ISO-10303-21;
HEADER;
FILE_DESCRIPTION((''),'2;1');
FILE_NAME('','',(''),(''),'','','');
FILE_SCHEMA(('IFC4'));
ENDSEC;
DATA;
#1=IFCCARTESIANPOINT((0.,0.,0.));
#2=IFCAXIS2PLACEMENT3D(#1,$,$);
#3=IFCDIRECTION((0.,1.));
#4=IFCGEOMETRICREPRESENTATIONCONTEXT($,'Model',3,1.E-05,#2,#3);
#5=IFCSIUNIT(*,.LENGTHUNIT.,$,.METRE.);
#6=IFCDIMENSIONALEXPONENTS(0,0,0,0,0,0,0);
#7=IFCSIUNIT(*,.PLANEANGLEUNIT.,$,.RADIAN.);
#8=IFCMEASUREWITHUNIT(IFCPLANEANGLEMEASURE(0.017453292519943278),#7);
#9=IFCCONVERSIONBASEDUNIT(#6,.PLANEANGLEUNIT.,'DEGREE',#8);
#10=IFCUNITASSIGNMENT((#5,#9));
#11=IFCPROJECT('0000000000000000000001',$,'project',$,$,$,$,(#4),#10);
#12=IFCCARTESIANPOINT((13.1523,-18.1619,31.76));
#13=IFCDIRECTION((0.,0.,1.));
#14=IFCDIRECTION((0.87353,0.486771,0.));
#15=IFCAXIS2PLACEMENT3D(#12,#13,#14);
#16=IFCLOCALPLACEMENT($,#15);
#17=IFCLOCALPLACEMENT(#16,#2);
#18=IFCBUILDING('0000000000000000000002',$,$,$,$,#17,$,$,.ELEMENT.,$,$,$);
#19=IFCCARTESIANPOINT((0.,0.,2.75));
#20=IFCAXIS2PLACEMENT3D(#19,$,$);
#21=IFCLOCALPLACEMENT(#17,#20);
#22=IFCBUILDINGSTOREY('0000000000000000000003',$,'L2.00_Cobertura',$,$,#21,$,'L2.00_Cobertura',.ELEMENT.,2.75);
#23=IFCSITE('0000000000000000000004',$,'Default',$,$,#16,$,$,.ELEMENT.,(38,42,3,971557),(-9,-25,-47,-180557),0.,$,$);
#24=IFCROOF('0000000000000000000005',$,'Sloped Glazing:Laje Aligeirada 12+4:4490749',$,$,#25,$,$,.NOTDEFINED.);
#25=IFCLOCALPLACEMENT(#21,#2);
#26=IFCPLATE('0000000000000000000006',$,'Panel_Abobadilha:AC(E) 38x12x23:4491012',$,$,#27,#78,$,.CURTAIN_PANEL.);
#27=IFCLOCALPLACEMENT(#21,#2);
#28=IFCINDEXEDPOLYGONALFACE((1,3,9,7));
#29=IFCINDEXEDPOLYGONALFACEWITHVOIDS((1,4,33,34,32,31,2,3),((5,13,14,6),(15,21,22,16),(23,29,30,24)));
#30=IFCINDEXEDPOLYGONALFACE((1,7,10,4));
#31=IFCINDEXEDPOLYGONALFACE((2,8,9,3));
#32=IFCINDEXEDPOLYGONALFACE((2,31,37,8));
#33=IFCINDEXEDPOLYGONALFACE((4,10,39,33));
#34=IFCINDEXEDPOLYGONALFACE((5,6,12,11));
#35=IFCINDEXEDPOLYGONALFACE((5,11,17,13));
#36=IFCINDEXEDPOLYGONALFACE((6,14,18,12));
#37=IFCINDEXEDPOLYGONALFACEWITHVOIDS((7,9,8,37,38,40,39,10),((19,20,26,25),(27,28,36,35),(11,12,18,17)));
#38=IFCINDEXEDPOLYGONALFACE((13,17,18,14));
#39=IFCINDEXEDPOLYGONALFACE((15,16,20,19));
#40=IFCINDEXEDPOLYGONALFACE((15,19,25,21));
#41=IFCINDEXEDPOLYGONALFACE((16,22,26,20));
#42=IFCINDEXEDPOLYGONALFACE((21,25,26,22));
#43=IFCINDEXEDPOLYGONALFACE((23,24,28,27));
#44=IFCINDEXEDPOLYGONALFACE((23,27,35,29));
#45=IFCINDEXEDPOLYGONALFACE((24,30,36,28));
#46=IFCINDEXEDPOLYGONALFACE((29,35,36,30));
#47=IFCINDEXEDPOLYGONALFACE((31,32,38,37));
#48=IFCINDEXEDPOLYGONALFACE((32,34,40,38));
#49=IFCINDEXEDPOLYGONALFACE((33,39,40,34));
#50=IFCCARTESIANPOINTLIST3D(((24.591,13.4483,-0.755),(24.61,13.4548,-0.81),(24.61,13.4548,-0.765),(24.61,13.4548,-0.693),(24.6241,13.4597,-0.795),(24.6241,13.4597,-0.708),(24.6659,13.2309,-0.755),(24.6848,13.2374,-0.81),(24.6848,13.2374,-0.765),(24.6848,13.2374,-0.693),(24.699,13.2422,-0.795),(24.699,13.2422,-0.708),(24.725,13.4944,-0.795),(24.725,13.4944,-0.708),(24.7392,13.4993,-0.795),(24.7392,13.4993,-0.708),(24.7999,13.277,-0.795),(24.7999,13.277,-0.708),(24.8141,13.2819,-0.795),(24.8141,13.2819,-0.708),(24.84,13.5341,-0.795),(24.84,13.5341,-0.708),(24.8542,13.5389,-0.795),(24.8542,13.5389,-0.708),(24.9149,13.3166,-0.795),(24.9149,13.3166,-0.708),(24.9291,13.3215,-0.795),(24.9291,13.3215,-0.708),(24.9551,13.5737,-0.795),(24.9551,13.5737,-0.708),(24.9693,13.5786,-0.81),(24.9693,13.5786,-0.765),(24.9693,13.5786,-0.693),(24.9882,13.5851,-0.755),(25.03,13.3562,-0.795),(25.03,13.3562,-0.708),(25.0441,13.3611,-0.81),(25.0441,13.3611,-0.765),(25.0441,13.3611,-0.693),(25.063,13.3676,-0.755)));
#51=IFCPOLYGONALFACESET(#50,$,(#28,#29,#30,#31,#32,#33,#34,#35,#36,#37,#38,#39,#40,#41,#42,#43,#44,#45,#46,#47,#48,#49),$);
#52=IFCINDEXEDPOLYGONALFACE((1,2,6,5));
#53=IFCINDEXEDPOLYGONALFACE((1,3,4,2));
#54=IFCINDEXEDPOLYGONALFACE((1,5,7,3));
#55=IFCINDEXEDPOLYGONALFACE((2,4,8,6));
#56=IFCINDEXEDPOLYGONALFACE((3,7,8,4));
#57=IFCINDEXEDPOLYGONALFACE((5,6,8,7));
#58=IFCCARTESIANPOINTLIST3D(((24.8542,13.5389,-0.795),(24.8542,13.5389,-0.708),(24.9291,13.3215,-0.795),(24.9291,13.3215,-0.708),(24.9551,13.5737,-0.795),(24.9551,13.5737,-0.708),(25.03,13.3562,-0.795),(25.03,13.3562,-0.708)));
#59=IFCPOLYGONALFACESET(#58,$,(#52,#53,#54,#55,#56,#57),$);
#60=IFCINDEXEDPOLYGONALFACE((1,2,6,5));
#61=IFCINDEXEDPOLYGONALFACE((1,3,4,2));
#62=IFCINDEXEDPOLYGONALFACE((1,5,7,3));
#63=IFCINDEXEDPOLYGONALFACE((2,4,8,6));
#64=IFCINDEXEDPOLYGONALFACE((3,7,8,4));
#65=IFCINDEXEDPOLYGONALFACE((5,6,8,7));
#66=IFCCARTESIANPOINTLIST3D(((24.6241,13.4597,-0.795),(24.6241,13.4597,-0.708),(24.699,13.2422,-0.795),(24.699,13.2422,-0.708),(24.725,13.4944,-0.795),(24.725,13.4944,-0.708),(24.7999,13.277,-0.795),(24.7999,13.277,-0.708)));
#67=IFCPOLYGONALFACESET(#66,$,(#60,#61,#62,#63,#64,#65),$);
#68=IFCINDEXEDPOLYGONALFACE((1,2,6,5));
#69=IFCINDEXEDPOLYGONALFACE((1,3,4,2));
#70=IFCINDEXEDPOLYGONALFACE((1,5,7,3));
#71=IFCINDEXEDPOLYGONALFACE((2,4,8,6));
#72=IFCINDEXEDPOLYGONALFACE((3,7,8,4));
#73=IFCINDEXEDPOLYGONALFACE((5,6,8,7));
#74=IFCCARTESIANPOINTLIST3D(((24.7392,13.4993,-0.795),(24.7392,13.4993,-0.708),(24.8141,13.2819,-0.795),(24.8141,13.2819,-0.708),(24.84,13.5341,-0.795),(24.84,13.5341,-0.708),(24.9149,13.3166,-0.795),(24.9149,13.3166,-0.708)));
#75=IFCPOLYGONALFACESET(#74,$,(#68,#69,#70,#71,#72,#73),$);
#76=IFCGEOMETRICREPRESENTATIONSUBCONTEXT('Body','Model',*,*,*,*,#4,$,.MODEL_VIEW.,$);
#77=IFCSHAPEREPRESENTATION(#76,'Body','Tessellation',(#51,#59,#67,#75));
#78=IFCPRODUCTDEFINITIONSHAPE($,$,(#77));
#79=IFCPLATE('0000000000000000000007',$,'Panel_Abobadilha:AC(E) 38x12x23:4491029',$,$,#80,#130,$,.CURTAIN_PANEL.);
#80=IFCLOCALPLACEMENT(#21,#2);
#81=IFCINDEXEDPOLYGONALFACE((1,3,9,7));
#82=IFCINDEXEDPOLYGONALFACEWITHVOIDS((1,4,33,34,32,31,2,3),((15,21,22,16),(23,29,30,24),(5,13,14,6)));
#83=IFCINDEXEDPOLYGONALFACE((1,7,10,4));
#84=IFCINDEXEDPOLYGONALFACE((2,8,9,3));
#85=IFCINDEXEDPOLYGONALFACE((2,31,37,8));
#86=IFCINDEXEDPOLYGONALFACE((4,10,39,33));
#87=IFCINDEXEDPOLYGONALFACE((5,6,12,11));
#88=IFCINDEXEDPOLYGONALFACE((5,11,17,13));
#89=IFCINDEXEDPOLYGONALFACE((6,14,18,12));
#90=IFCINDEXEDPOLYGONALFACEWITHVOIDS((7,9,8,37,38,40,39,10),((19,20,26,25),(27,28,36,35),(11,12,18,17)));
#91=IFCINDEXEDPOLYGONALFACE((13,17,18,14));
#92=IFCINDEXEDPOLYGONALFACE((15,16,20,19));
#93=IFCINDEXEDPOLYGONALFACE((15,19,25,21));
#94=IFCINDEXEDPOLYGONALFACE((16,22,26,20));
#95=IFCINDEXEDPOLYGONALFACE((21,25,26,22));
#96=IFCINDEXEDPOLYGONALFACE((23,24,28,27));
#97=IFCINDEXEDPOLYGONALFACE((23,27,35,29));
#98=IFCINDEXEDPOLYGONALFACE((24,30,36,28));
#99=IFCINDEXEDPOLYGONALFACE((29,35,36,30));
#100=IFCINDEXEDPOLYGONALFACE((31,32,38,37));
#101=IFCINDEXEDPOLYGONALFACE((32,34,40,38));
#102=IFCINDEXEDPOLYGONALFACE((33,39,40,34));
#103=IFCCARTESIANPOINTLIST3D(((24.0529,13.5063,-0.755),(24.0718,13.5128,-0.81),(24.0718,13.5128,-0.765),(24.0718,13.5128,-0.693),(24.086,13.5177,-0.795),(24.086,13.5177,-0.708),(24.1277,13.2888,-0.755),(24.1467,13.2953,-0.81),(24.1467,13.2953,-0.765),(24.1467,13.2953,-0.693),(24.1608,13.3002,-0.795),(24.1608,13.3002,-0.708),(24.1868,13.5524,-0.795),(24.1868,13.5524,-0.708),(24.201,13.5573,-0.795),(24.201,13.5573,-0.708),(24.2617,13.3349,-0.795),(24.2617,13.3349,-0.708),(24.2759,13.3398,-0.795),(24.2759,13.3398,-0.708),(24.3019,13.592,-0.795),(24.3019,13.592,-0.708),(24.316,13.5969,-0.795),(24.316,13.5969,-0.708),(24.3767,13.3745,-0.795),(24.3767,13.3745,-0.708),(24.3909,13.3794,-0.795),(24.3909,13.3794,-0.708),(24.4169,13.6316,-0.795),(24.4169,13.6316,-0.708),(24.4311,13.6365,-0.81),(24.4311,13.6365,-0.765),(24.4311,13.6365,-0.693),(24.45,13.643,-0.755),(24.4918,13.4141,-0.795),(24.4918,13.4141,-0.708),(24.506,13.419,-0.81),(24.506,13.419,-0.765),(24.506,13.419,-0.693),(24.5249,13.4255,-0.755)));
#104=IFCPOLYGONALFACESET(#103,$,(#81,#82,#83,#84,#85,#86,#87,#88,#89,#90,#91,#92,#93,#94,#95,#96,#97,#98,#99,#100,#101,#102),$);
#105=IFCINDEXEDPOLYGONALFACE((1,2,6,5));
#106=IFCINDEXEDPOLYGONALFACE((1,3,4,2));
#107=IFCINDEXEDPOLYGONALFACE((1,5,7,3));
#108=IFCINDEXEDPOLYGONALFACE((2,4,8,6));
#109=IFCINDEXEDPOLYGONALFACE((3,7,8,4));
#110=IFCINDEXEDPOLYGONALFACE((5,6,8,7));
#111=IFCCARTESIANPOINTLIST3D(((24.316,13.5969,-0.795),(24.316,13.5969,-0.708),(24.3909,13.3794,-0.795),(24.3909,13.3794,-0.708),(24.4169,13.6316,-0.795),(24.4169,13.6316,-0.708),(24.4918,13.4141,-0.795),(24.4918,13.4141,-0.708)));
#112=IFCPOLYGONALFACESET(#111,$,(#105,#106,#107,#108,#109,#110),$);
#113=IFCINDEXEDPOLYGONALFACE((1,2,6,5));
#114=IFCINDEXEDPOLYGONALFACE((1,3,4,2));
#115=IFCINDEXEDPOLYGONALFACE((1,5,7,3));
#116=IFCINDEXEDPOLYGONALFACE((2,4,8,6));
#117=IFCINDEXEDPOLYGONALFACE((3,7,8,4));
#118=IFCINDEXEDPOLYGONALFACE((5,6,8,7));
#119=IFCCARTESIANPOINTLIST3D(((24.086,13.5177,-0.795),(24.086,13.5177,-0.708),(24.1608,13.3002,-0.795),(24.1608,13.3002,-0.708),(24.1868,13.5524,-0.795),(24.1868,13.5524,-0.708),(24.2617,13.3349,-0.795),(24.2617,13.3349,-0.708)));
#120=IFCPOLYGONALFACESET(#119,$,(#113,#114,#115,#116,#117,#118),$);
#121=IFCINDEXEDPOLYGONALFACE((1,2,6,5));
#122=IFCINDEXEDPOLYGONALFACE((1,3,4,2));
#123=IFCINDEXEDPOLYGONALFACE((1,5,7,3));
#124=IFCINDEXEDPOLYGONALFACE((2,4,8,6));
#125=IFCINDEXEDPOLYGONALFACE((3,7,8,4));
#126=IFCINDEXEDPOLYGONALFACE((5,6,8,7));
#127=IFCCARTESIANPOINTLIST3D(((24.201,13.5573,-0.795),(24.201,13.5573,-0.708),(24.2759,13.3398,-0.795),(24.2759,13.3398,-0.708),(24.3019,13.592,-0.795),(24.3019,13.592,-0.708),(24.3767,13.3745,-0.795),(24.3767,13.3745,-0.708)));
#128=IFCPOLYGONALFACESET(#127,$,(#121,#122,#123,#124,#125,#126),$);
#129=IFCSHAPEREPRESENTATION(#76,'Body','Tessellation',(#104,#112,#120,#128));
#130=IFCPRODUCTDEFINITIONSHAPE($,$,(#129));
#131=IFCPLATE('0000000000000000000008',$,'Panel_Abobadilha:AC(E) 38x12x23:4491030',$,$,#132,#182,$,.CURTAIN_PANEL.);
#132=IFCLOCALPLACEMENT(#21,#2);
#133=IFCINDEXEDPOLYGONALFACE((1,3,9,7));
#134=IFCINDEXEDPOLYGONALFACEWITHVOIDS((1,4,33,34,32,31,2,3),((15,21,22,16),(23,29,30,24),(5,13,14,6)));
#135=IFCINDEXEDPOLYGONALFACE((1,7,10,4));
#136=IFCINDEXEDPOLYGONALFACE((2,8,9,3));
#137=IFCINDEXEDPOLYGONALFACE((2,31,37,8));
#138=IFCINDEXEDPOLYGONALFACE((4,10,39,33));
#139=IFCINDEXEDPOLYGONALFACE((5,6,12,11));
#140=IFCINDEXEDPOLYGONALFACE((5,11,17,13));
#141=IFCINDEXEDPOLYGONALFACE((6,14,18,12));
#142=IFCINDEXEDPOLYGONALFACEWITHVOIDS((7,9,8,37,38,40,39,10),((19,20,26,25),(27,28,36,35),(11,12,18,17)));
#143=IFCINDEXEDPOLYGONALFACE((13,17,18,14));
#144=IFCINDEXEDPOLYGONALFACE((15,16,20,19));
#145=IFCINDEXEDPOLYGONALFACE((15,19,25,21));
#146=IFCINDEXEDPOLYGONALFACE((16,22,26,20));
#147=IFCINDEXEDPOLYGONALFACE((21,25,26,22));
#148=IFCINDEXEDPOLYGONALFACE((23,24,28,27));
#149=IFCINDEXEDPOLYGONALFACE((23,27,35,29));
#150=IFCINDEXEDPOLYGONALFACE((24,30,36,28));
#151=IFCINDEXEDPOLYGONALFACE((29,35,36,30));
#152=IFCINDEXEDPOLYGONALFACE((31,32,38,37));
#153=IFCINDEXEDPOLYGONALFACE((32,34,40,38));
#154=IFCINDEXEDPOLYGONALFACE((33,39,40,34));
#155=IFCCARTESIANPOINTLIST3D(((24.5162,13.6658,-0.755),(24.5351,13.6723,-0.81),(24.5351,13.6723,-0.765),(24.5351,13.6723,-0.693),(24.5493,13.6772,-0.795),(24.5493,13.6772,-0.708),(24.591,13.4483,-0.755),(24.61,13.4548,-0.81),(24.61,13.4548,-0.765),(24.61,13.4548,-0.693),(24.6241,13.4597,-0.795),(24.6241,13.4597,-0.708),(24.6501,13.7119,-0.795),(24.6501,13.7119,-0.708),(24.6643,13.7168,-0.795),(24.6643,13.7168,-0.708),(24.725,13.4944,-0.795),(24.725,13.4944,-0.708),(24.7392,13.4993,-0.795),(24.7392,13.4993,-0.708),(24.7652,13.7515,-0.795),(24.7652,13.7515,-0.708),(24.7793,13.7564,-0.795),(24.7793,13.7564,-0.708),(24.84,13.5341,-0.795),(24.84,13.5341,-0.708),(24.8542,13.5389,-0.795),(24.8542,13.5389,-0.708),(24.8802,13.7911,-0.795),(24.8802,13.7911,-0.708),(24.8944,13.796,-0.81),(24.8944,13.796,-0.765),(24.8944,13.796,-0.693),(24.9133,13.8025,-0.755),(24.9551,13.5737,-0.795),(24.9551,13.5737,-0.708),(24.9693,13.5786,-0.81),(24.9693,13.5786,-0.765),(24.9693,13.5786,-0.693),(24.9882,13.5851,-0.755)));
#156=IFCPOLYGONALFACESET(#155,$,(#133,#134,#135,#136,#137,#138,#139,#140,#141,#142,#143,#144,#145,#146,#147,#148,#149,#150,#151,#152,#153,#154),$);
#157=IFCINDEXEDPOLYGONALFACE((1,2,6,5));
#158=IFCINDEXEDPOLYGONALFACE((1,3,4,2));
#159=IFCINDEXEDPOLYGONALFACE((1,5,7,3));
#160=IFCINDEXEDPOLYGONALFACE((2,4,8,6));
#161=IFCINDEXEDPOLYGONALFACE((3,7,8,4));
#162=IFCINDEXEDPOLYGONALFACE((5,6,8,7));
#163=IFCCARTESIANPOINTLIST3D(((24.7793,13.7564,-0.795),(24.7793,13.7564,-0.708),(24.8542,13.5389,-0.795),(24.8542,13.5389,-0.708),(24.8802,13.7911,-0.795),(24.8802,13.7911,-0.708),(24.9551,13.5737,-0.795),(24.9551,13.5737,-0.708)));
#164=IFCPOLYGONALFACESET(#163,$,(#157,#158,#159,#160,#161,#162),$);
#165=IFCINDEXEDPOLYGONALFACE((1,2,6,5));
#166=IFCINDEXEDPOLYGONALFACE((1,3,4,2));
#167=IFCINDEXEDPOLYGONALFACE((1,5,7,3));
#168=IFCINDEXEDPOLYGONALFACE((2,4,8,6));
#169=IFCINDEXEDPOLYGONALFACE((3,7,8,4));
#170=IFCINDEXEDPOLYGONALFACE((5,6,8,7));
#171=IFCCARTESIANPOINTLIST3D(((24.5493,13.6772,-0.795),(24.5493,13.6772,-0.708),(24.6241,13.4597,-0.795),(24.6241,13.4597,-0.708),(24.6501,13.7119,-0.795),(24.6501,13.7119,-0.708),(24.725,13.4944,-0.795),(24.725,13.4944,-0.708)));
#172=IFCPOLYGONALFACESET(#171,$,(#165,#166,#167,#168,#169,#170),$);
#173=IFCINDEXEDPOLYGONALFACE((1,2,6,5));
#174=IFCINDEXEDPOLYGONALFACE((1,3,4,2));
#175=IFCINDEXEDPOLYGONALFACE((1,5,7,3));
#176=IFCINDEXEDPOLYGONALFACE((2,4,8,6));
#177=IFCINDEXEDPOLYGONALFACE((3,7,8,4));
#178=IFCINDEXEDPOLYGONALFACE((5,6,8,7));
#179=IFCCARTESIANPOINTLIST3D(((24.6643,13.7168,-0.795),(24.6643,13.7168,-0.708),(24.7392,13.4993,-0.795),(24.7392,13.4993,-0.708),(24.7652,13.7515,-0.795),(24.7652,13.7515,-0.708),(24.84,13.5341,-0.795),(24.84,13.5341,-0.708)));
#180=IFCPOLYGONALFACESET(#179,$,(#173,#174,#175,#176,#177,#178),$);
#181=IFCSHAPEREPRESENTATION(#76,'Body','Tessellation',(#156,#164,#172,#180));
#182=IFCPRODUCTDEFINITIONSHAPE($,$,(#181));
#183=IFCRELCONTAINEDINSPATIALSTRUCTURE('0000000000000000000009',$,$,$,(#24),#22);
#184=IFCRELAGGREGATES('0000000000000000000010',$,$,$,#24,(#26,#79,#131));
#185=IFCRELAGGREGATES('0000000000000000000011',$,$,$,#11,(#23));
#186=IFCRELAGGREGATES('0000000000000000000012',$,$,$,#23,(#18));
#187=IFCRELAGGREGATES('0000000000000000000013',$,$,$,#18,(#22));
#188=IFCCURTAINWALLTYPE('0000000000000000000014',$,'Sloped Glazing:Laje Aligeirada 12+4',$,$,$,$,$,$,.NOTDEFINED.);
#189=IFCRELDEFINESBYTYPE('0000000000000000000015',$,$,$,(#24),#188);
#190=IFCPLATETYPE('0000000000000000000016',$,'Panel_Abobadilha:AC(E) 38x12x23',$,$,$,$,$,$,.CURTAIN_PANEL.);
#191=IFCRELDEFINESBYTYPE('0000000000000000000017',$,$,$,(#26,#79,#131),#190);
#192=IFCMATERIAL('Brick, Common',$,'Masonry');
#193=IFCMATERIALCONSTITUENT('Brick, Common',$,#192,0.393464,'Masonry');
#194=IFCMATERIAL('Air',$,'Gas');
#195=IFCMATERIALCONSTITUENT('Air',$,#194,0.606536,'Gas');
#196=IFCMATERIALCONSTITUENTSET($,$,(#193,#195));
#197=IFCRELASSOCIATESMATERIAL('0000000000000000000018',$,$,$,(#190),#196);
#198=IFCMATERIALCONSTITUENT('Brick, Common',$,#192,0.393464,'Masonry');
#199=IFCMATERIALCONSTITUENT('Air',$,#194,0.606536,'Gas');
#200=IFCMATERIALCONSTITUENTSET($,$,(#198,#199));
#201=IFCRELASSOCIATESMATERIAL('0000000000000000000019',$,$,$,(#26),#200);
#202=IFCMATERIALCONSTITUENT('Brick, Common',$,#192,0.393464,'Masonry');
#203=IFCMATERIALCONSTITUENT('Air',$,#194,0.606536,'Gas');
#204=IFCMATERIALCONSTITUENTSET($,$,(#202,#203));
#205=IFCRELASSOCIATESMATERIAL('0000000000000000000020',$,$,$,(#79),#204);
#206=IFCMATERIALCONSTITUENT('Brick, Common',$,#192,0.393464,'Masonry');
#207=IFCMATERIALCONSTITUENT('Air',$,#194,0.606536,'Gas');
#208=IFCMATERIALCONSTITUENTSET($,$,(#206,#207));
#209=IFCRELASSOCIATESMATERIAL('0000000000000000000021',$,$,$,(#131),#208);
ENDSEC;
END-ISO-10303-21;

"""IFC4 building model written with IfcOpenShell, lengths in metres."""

from ifc_helpers import new_model, entity, si_unit, converted_unit, direction, frame, origin, place, context, subcontext, project, spatial, indexed_curve, outline, extrude, source, transform, mapped, material, constituent, constituent_set, type_object, type_shapes, element, aggregate, save


model = new_model("IFC4")

# Units and contexts
model_context = context("Model", 3, precision=1e-05, world=origin(), true_north=direction((0.0, 1.0)))
body_context = subcontext(model_context, "Body", "Model", "MODEL_VIEW")
ifc_project = project(units=[si_unit("LENGTHUNIT", "METRE"), converted_unit("PLANEANGLEUNIT", "DEGREE", entity("IfcPlaneAngleMeasure", 0.017453292519943278), si_unit("PLANEANGLEUNIT", "RADIAN"), dimensions=[0, 0, 0, 0, 0, 0, 0])], contexts=[model_context])

# Site, building, storey
site_placement = place(None, frame((13.1523, -18.1619, 31.76), z_axis=(0.0, 0.0, 1.0), x_axis=(0.87353, 0.486771, 0.0)))
site = spatial("IfcSite", under=ifc_project, at=site_placement, Name="Default", CompositionType="ELEMENT", RefLatitude=(38, 42, 3, 971557), RefLongitude=(-9, -25, -47, -180557), RefElevation=0.0)
building_placement = place(site_placement, origin())
building = spatial("IfcBuilding", under=site, at=building_placement, CompositionType="ELEMENT")
storey_placement = place(building_placement, frame((0.0, 0.0, 2.75)))
storey = spatial("IfcBuildingStorey", under=building, at=storey_placement, Name="L2.00_Cobertura", LongName="L2.00_Cobertura", CompositionType="ELEMENT", Elevation=2.75)

# Roof, plates
curtain_wall_type = type_object("IfcCurtainWallType", Name="Sloped Glazing:Laje Aligeirada 12+4", PredefinedType="NOTDEFINED")
roof_placement = place(storey_placement, frame((0.0, 0.0, -2.75)))
roof = element("IfcRoof", 1, at=roof_placement, inside=storey, type_object=curtain_wall_type, Name="Sloped Glazing:Laje Aligeirada 12+4:4490749", PredefinedType="NOTDEFINED")
ifc_material_1 = material(Name="Brick, Common", Category="Masonry")
ifc_constituent_1 = constituent(ifc_material_1, Name="Brick, Common", Category="Masonry", fraction=0.393464)
ifc_material_2 = material(Name="Air", Category="Gas")
ifc_constituent_2 = constituent(ifc_material_2, Name="Air", Category="Gas", fraction=0.606536)
ifc_constituent_set_1 = constituent_set(constituents=[ifc_constituent_1, ifc_constituent_2])
ifc_constituent_3 = constituent(ifc_material_1, Name="Brick, Common", Category="Masonry", fraction=0.393464)
ifc_constituent_4 = constituent(ifc_material_2, Name="Air", Category="Gas", fraction=0.606536)
ifc_constituent_set_2 = constituent_set(constituents=[ifc_constituent_3, ifc_constituent_4])
plate_type = type_object("IfcPlateType", Name="Panel_Abobadilha:AC(E) 38x12x23", PredefinedType="CURTAIN_PANEL", material=ifc_constituent_set_2)
shared_shape_1 = source(origin(), body_context, "Body", "SweptSolid", [
    extrude(outline(indexed_curve([(-0.19, -0.0543), (0.19, -0.0543), (0.19, -0.0093), (0.21, 0.0007), (0.19, 0.0628), (-0.19, 0.0628), (-0.21, 0.0007), (-0.19, -0.0093), (-0.19, -0.0543)], self_intersect=False), holes=[indexed_curve([(-0.0683, 0.0477), (-0.0683, -0.0393), (-0.175, -0.0393), (-0.175, 0.0477), (-0.0683, 0.0477)], self_intersect=False), indexed_curve([(0.0533, 0.0477), (0.0533, -0.0393), (-0.0533, -0.0393), (-0.0533, 0.0477), (0.0533, 0.0477)], self_intersect=False), indexed_curve([(0.175, 0.0477), (0.175, -0.0393), (0.0683, -0.0393), (0.0683, 0.0477), (0.175, 0.0477)], self_intersect=False)]), frame((0.0, 0.0543, 0.0)), (0.0, 0.0, 1.0), 0.23),
    extrude(outline(indexed_curve([(-0.0533, -0.0435), (0.0533, -0.0435), (0.0533, 0.0435), (-0.0533, 0.0435), (-0.0533, -0.0435)], self_intersect=False)), frame((0.1217, 0.0585, 0.0), z_axis=(0.0, 0.0, 1.0), x_axis=(-1.0, 0.0, 0.0)), (0.0, 0.0, 1.0), 0.23),
    extrude(outline(indexed_curve([(-0.0533, -0.0435), (0.0533, -0.0435), (0.0533, 0.0435), (-0.0533, 0.0435), (-0.0533, -0.0435)], self_intersect=False)), frame((-0.1217, 0.0585, 0.0), z_axis=(0.0, 0.0, 1.0), x_axis=(-1.0, 0.0, 0.0)), (0.0, 0.0, 1.0), 0.23),
    extrude(outline(indexed_curve([(-0.0533, -0.0435), (0.0533, -0.0435), (0.0533, 0.0435), (-0.0533, 0.0435), (-0.0533, -0.0435)], self_intersect=False)), frame((0.0, 0.0585, 0.0), z_axis=(0.0, 0.0, 1.0), x_axis=(-1.0, 0.0, 0.0)), (0.0, 0.0, 1.0), 0.23),
])
type_shapes(plate_type, [shared_shape_1])
plate_1_placement = place(roof_placement, frame((24.7896, 13.5167, 1.94), z_axis=(0.325568, -0.945519, 0.0), x_axis=(0.945519, 0.325568, 0.0)))
plate_1 = element("IfcPlate", 2, at=plate_1_placement, type_object=plate_type, material=ifc_constituent_set_1, Name="Panel_Abobadilha:AC(E) 38x12x23:4491012", PredefinedType="CURTAIN_PANEL", context=body_context, shape_type="MappedRepresentation", body=[
    mapped(shared_shape_1, transform((0.0, 0.0, 0.0), scale=1.0)),
])
ifc_constituent_5 = constituent(ifc_material_1, Name="Brick, Common", Category="Masonry", fraction=0.393464)
ifc_constituent_6 = constituent(ifc_material_2, Name="Air", Category="Gas", fraction=0.606536)
ifc_constituent_set_3 = constituent_set(constituents=[ifc_constituent_5, ifc_constituent_6])
plate_2_placement = place(roof_placement, frame((24.2514, 13.5746, 1.94), z_axis=(0.325568, -0.945519, 0.0), x_axis=(0.945519, 0.325568, 0.0)))
plate_2 = element("IfcPlate", 3, at=plate_2_placement, type_object=plate_type, material=ifc_constituent_set_3, Name="Panel_Abobadilha:AC(E) 38x12x23:4491029", PredefinedType="CURTAIN_PANEL", context=body_context, shape_type="MappedRepresentation", body=[
    mapped(shared_shape_1, transform((0.0, 0.0, 0.0), scale=1.0)),
])
ifc_constituent_7 = constituent(ifc_material_1, Name="Brick, Common", Category="Masonry", fraction=0.393464)
ifc_constituent_8 = constituent(ifc_material_2, Name="Air", Category="Gas", fraction=0.606536)
ifc_constituent_set_4 = constituent_set(constituents=[ifc_constituent_7, ifc_constituent_8])
plate_3_placement = place(roof_placement, frame((24.7147, 13.7342, 1.94), z_axis=(0.325568, -0.945519, 0.0), x_axis=(0.945519, 0.325568, 0.0)))
plate_3 = element("IfcPlate", 4, at=plate_3_placement, type_object=plate_type, material=ifc_constituent_set_4, Name="Panel_Abobadilha:AC(E) 38x12x23:4491030", PredefinedType="CURTAIN_PANEL", context=body_context, shape_type="MappedRepresentation", body=[
    mapped(shared_shape_1, transform((0.0, 0.0, 0.0), scale=1.0)),
])
aggregate(roof, [plate_1, plate_2, plate_3])

save(model, "model.ifc")
